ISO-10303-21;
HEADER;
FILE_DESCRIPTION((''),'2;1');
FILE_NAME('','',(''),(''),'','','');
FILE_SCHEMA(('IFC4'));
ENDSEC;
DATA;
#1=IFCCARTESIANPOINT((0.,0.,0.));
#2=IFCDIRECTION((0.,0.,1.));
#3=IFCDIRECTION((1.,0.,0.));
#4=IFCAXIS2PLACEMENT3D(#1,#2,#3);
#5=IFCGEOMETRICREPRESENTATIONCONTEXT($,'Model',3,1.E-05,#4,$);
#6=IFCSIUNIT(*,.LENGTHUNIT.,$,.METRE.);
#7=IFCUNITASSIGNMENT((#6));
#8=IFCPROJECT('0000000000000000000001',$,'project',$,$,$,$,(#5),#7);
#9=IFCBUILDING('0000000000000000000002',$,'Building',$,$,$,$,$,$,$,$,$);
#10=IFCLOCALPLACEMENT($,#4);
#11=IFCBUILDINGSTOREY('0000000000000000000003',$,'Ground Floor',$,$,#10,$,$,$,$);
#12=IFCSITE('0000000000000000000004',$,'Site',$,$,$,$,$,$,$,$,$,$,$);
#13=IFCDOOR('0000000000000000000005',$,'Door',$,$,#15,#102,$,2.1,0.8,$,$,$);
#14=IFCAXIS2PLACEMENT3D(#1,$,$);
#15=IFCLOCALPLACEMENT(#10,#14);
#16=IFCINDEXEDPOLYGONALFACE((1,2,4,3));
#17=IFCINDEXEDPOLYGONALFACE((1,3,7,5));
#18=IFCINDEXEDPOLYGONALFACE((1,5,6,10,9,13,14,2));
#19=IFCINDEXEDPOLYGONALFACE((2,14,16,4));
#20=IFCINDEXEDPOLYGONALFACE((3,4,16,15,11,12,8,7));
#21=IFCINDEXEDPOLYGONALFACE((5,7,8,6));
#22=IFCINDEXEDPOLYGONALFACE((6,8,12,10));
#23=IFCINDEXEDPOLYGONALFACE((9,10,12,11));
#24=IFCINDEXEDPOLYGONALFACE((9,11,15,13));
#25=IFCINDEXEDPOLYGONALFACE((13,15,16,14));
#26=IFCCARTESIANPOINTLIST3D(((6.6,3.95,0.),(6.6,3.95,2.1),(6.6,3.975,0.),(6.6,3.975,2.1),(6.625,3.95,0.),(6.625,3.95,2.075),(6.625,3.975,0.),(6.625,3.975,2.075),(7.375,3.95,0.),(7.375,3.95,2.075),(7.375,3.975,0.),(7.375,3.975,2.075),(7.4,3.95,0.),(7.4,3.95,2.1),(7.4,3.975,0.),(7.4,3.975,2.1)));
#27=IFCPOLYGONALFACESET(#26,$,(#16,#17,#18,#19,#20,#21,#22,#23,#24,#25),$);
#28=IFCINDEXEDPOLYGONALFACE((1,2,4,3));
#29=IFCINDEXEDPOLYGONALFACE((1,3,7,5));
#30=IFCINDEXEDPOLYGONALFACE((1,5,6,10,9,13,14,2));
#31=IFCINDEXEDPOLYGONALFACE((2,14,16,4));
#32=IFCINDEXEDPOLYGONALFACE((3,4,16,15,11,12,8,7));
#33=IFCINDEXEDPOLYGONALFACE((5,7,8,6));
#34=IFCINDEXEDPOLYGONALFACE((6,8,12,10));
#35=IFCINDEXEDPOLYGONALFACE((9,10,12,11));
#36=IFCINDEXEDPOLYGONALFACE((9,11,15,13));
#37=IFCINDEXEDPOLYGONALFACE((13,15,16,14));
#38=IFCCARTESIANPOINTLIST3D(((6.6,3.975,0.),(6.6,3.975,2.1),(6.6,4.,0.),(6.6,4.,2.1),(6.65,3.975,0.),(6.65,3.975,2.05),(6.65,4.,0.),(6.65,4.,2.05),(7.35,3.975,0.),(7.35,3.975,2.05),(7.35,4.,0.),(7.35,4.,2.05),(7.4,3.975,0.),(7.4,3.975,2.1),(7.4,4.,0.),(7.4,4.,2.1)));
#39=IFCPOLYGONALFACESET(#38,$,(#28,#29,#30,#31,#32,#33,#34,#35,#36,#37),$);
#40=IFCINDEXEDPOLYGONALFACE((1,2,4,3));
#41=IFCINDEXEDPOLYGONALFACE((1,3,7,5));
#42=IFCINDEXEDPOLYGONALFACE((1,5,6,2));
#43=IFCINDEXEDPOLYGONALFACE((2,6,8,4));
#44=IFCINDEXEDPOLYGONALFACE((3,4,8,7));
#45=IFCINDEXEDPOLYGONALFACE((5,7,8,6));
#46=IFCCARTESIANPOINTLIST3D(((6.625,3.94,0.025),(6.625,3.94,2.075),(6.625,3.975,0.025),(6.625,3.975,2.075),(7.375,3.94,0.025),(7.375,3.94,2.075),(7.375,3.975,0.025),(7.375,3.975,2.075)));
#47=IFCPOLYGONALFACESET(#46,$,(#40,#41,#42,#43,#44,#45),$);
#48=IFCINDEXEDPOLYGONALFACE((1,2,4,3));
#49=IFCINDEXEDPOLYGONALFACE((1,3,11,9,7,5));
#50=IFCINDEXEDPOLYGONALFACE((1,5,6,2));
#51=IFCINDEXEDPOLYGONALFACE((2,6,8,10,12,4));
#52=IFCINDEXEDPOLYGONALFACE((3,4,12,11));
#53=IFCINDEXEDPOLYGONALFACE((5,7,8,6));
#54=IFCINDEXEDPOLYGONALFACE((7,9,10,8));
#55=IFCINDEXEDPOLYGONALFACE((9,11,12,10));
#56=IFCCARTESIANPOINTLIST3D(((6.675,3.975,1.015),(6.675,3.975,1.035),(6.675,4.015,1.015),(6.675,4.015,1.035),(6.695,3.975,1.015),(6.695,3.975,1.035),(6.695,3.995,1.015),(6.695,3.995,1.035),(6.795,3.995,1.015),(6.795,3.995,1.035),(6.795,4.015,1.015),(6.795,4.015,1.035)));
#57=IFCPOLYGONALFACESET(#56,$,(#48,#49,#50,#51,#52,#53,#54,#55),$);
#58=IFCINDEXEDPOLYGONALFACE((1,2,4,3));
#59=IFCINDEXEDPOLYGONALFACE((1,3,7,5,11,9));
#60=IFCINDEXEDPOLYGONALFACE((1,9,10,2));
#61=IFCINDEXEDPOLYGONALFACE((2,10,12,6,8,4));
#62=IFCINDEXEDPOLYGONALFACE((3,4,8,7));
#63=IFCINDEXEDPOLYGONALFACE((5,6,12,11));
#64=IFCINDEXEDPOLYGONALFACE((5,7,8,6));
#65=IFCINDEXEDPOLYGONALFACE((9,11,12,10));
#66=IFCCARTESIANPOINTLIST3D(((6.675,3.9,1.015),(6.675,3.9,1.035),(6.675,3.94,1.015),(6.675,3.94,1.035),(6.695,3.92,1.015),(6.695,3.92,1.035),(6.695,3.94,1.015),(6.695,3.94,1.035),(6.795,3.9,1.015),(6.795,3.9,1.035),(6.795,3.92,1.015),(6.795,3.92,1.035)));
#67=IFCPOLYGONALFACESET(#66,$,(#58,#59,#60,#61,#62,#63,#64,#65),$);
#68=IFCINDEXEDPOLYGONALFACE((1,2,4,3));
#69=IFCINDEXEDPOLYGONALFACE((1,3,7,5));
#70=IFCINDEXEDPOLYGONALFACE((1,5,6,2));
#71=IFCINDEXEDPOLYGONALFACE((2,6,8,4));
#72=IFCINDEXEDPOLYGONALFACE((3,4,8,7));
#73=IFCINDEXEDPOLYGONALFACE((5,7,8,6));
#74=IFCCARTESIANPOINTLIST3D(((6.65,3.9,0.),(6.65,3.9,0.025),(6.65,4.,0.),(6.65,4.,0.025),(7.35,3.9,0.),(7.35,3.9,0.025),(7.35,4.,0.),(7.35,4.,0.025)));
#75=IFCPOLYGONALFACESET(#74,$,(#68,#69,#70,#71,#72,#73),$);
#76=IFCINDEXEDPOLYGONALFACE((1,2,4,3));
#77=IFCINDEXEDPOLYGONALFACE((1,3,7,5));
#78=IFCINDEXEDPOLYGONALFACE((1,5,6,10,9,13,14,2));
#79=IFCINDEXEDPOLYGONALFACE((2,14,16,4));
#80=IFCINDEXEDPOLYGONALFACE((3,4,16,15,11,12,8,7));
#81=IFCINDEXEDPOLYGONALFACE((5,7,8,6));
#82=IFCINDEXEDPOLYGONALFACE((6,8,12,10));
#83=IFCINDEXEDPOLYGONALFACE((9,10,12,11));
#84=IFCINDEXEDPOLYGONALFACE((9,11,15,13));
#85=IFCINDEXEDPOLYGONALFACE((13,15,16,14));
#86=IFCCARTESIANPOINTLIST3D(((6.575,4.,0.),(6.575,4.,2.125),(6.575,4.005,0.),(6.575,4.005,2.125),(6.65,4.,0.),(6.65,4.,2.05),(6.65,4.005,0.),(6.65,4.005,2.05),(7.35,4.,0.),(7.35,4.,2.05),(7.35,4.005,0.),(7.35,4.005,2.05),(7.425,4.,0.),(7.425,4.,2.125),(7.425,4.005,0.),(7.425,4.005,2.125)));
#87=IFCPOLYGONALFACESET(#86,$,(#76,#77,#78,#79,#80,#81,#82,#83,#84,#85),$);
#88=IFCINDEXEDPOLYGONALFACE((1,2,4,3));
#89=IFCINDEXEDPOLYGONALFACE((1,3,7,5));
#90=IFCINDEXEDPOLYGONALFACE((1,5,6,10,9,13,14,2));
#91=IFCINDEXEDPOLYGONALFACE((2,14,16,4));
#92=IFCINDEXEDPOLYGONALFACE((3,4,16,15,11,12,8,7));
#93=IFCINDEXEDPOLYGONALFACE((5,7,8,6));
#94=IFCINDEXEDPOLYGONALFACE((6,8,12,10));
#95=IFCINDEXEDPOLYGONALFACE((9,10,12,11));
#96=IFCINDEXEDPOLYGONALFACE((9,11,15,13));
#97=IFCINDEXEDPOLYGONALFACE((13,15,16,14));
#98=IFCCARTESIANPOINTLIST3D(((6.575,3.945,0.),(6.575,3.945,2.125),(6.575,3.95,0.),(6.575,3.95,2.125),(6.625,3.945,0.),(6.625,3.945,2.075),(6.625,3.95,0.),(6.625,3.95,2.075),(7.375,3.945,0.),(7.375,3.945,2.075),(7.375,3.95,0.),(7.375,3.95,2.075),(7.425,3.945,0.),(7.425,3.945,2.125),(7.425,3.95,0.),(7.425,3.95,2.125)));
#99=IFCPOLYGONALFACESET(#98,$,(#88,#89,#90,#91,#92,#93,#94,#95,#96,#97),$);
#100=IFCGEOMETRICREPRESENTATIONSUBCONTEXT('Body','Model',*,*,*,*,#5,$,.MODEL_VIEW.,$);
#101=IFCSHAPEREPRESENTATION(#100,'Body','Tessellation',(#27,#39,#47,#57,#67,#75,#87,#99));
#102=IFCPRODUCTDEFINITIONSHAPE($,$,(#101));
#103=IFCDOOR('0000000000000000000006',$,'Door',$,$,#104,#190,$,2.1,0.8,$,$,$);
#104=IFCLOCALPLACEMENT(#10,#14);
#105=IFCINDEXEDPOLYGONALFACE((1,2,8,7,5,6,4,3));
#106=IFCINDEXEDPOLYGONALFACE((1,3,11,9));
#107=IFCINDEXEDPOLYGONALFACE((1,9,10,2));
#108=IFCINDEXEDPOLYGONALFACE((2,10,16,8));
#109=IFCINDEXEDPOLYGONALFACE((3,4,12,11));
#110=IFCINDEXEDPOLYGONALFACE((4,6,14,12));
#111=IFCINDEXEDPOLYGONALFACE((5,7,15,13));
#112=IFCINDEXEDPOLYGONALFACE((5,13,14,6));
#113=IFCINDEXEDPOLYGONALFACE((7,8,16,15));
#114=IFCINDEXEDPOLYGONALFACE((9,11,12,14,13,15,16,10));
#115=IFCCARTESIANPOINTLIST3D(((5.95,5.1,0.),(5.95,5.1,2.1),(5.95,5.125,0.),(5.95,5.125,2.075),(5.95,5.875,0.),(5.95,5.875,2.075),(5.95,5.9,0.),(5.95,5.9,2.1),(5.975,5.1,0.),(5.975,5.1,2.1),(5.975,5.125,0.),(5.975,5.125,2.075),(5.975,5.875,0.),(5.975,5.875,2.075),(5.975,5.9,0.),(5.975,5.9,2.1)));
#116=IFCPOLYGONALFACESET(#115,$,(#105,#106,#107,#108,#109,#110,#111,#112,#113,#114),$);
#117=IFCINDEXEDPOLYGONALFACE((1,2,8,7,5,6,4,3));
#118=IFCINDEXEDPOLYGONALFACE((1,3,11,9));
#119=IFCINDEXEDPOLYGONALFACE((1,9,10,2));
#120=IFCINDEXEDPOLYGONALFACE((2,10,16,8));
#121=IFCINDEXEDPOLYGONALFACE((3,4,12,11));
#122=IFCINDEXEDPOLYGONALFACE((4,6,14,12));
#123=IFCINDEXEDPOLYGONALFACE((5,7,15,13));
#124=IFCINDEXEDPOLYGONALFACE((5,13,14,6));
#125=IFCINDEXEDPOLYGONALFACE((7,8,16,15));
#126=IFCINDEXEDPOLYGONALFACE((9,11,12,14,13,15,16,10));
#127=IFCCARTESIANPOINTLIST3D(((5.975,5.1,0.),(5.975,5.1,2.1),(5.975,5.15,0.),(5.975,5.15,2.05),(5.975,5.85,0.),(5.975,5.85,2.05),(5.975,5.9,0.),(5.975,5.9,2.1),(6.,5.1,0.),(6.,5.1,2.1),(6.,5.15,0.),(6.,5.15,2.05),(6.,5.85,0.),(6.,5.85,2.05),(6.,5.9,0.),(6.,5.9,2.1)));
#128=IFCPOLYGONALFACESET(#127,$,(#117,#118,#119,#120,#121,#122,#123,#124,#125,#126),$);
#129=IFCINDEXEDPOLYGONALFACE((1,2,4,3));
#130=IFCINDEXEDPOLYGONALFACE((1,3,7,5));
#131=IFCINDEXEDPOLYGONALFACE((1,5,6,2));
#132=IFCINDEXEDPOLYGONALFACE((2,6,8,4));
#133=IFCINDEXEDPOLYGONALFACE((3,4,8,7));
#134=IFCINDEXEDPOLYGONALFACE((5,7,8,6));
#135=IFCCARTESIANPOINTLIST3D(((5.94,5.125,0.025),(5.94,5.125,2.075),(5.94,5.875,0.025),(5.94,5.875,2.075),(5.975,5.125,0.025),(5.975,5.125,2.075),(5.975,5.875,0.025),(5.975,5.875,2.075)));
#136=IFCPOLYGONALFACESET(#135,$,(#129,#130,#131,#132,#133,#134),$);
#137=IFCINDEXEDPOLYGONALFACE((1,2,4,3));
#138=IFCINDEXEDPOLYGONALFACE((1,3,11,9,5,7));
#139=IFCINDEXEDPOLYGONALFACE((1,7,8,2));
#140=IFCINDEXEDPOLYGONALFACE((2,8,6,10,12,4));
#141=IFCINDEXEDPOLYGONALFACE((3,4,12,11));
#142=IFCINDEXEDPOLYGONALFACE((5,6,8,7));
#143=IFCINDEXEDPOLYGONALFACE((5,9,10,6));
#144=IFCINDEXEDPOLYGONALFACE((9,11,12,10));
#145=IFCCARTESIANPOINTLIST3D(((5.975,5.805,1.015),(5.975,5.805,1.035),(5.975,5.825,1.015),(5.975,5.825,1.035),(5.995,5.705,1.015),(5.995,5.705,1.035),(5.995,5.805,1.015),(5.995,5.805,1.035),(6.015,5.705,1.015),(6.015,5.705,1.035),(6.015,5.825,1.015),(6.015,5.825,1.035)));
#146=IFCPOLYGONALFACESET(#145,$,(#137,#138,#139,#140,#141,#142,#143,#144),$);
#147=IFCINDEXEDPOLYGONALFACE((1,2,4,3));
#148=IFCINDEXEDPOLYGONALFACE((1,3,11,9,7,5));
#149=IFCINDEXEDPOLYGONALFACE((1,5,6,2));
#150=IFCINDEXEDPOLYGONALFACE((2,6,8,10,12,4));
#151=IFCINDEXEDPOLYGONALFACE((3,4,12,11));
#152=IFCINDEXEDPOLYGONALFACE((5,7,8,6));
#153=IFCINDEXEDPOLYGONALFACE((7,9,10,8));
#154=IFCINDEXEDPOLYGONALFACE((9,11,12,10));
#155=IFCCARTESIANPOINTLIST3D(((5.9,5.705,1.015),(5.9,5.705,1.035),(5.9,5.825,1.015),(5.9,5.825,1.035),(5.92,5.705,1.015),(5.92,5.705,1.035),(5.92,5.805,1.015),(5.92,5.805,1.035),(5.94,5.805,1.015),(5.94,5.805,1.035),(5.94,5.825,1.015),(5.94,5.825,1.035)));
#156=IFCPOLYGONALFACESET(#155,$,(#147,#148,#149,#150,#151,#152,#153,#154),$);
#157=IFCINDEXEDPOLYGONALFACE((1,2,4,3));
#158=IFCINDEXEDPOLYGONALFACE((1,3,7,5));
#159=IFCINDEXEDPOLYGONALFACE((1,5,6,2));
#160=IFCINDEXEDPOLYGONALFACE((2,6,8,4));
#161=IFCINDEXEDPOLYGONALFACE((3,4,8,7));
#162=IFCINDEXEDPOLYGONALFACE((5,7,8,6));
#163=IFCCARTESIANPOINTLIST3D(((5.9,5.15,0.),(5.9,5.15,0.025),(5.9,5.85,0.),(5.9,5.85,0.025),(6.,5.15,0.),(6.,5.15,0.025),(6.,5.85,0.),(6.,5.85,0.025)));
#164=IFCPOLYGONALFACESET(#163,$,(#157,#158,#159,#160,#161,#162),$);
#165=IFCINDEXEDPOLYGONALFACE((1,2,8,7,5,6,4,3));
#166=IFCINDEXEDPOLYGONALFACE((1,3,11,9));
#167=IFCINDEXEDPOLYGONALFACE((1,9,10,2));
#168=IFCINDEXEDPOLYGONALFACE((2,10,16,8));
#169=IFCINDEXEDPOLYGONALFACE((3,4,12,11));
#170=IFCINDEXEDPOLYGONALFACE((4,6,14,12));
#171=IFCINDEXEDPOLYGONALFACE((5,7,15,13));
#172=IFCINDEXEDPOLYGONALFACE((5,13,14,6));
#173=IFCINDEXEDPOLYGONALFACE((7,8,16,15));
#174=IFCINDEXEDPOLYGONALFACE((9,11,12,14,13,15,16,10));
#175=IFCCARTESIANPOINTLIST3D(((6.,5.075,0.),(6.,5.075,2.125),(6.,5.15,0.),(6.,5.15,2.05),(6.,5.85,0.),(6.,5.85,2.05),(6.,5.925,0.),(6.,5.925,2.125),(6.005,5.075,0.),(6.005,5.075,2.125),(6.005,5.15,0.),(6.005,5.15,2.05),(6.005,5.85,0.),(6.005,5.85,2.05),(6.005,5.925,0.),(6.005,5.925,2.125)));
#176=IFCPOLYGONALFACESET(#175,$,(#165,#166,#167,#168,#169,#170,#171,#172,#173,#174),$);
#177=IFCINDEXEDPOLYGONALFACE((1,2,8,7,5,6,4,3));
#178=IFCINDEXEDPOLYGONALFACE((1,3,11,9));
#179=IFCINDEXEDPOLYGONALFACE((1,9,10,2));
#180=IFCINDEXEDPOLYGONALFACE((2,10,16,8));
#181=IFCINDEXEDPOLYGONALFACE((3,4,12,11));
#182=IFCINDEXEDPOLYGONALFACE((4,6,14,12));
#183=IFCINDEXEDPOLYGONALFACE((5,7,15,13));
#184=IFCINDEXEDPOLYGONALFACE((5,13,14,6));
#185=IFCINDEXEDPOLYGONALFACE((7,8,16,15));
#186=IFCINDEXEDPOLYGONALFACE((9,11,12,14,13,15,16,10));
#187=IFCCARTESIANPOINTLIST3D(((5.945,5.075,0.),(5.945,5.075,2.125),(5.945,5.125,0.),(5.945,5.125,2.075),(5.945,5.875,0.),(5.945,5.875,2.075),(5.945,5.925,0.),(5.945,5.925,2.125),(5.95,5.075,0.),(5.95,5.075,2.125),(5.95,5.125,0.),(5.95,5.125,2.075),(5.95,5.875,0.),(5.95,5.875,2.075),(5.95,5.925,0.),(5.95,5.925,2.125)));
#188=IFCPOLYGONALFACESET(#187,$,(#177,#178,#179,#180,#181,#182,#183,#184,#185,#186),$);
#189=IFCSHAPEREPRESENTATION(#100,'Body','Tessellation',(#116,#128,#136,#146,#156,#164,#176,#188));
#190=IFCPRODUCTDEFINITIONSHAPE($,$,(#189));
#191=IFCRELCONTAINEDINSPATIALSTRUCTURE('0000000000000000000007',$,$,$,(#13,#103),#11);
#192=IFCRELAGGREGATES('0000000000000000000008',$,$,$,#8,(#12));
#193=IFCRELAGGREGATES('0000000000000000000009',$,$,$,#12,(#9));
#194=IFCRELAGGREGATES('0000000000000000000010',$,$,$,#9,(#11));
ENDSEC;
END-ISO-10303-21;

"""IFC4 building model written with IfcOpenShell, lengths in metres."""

from ifc_helpers import new_model, si_unit, frame, origin_with_axes, place, context, subcontext, project, spatial, line, indexed_curve, outline, extrude, element, save


model = new_model("IFC4")

# Units and contexts
model_context = context("Model", 3, precision=1e-05, world=origin_with_axes())
body_context = subcontext(model_context, "Body", "Model", "MODEL_VIEW")
ifc_project = project(units=[si_unit("LENGTHUNIT", "METRE")], contexts=[model_context])

# Site, building, storey
site = spatial("IfcSite", under=ifc_project, Name="Site")
building = spatial("IfcBuilding", under=site, Name="Building")
storey_placement = place(None, origin_with_axes())
storey = spatial("IfcBuildingStorey", under=building, at=storey_placement, Name="Ground Floor")

# Doors
door_1_placement = place(storey_placement, frame((7.4, 4.0, 0.0), z_axis=(0.0, 0.0, 1.0), x_axis=(-1.0, 0.0, 0.0)))
element("IfcDoor", 1, at=door_1_placement, inside=storey, Name="Door", OverallHeight=2.1, OverallWidth=0.8, context=body_context, shape_type="SweptSolid", body=[
    extrude(outline(indexed_curve([(0.0, 0.0), (0.0, 2.1), (0.8, 2.1), (0.8, 0.0), (0.775, 0.0), (0.775, 2.075), (0.025, 2.075), (0.025, 0.0)], segments=[line(1, 2, 3, 4, 5, 6, 7, 8, 1)])), frame((0.0, 0.025, 0.0), z_axis=(0.0, -1.0, 0.0), x_axis=(1.0, 0.0, 0.0)), (0.0, 0.0, -1.0), 0.025),
    extrude(outline(indexed_curve([(0.0, 0.0), (0.0, 2.1), (0.8, 2.1), (0.8, 0.0), (0.75, 0.0), (0.75, 2.05), (0.05, 2.05), (0.05, 0.0)], segments=[line(1, 2, 3, 4, 5, 6, 7, 8, 1)])), frame((0.0, 0.0, 0.0), z_axis=(0.0, -1.0, 0.0), x_axis=(1.0, 0.0, 0.0)), (0.0, 0.0, -1.0), 0.025),
    extrude(outline(indexed_curve([(0.0, 0.0), (0.75, 0.0), (0.75, 0.035), (0.0, 0.035)], segments=[line(1, 2, 3, 4, 1)])), frame((0.025, 0.025, 0.025), z_axis=(0.0, 0.0, 1.0), x_axis=(1.0, 0.0, 0.0)), (0.0, 0.0, 1.0), 2.05),
    extrude(outline(indexed_curve([(0.0, 0.0), (0.0, -0.04), (-0.12, -0.04), (-0.12, -0.02), (-0.02, -0.02), (-0.02, 0.0)], segments=[line(1, 2, 3, 4, 5, 6, 1)])), frame((0.725, 0.025, 1.015), z_axis=(0.0, 0.0, 1.0), x_axis=(1.0, 0.0, 0.0)), (0.0, 0.0, 1.0), 0.02),
    extrude(outline(indexed_curve([(0.0, 0.0), (0.0, 0.04), (-0.12, 0.04), (-0.12, 0.02), (-0.02, 0.02), (-0.02, 0.0)], segments=[line(1, 2, 3, 4, 5, 6, 1)])), frame((0.725, 0.06, 1.015), z_axis=(0.0, 0.0, 1.0), x_axis=(1.0, 0.0, 0.0)), (0.0, 0.0, 1.0), 0.02),
    extrude(outline(indexed_curve([(0.0, 0.0), (0.7, 0.0), (0.7, 0.1), (0.0, 0.1)], segments=[line(1, 2, 3, 4, 1)])), frame((0.05, 0.0, 0.0), z_axis=(0.0, 0.0, 1.0), x_axis=(1.0, 0.0, 0.0)), (0.0, 0.0, 1.0), 0.025),
    extrude(outline(indexed_curve([(0.0, 0.0), (0.0, 2.125), (0.85, 2.125), (0.85, 0.0), (0.775, 0.0), (0.775, 2.05), (0.075, 2.05), (0.075, 0.0)], segments=[line(1, 2, 3, 4, 5, 6, 7, 8, 1)])), frame((-0.025, -0.005, 0.0), z_axis=(0.0, -1.0, 0.0), x_axis=(1.0, 0.0, 0.0)), (0.0, 0.0, -1.0), 0.005),
    extrude(outline(indexed_curve([(0.0, 0.0), (0.0, 2.125), (0.85, 2.125), (0.85, 0.0), (0.8, 0.0), (0.8, 2.075), (0.05, 2.075), (0.05, 0.0)], segments=[line(1, 2, 3, 4, 5, 6, 7, 8, 1)])), frame((-0.025, 0.05, 0.0), z_axis=(0.0, -1.0, 0.0), x_axis=(1.0, 0.0, 0.0)), (0.0, 0.0, -1.0), 0.005),
])
door_2_placement = place(storey_placement, frame((6.0, 5.1, 0.0), z_axis=(0.0, 0.0, 1.0), x_axis=(0.0, 1.0, 0.0)))
element("IfcDoor", 2, at=door_2_placement, inside=storey, Name="Door", OverallHeight=2.1, OverallWidth=0.8, context=body_context, shape_type="SweptSolid", body=[
    extrude(outline(indexed_curve([(0.0, 0.0), (0.0, 2.1), (0.8, 2.1), (0.8, 0.0), (0.775, 0.0), (0.775, 2.075), (0.025, 2.075), (0.025, 0.0)], segments=[line(1, 2, 3, 4, 5, 6, 7, 8, 1)])), frame((0.0, 0.025, 0.0), z_axis=(0.0, -1.0, 0.0), x_axis=(1.0, 0.0, 0.0)), (0.0, 0.0, -1.0), 0.025),
    extrude(outline(indexed_curve([(0.0, 0.0), (0.0, 2.1), (0.8, 2.1), (0.8, 0.0), (0.75, 0.0), (0.75, 2.05), (0.05, 2.05), (0.05, 0.0)], segments=[line(1, 2, 3, 4, 5, 6, 7, 8, 1)])), frame((0.0, 0.0, 0.0), z_axis=(0.0, -1.0, 0.0), x_axis=(1.0, 0.0, 0.0)), (0.0, 0.0, -1.0), 0.025),
    extrude(outline(indexed_curve([(0.0, 0.0), (0.75, 0.0), (0.75, 0.035), (0.0, 0.035)], segments=[line(1, 2, 3, 4, 1)])), frame((0.025, 0.025, 0.025), z_axis=(0.0, 0.0, 1.0), x_axis=(1.0, 0.0, 0.0)), (0.0, 0.0, 1.0), 2.05),
    extrude(outline(indexed_curve([(0.0, 0.0), (0.0, -0.04), (-0.12, -0.04), (-0.12, -0.02), (-0.02, -0.02), (-0.02, 0.0)], segments=[line(1, 2, 3, 4, 5, 6, 1)])), frame((0.725, 0.025, 1.015), z_axis=(0.0, 0.0, 1.0), x_axis=(1.0, 0.0, 0.0)), (0.0, 0.0, 1.0), 0.02),
    extrude(outline(indexed_curve([(0.0, 0.0), (0.0, 0.04), (-0.12, 0.04), (-0.12, 0.02), (-0.02, 0.02), (-0.02, 0.0)], segments=[line(1, 2, 3, 4, 5, 6, 1)])), frame((0.725, 0.06, 1.015), z_axis=(0.0, 0.0, 1.0), x_axis=(1.0, 0.0, 0.0)), (0.0, 0.0, 1.0), 0.02),
    extrude(outline(indexed_curve([(0.0, 0.0), (0.7, 0.0), (0.7, 0.1), (0.0, 0.1)], segments=[line(1, 2, 3, 4, 1)])), frame((0.05, 0.0, 0.0), z_axis=(0.0, 0.0, 1.0), x_axis=(1.0, 0.0, 0.0)), (0.0, 0.0, 1.0), 0.025),
    extrude(outline(indexed_curve([(0.0, 0.0), (0.0, 2.125), (0.85, 2.125), (0.85, 0.0), (0.775, 0.0), (0.775, 2.05), (0.075, 2.05), (0.075, 0.0)], segments=[line(1, 2, 3, 4, 5, 6, 7, 8, 1)])), frame((-0.025, -0.005, 0.0), z_axis=(0.0, -1.0, 0.0), x_axis=(1.0, 0.0, 0.0)), (0.0, 0.0, -1.0), 0.005),
    extrude(outline(indexed_curve([(0.0, 0.0), (0.0, 2.125), (0.85, 2.125), (0.85, 0.0), (0.8, 0.0), (0.8, 2.075), (0.05, 2.075), (0.05, 0.0)], segments=[line(1, 2, 3, 4, 5, 6, 7, 8, 1)])), frame((-0.025, 0.05, 0.0), z_axis=(0.0, -1.0, 0.0), x_axis=(1.0, 0.0, 0.0)), (0.0, 0.0, -1.0), 0.005),
])

save(model, "model.ifc")
